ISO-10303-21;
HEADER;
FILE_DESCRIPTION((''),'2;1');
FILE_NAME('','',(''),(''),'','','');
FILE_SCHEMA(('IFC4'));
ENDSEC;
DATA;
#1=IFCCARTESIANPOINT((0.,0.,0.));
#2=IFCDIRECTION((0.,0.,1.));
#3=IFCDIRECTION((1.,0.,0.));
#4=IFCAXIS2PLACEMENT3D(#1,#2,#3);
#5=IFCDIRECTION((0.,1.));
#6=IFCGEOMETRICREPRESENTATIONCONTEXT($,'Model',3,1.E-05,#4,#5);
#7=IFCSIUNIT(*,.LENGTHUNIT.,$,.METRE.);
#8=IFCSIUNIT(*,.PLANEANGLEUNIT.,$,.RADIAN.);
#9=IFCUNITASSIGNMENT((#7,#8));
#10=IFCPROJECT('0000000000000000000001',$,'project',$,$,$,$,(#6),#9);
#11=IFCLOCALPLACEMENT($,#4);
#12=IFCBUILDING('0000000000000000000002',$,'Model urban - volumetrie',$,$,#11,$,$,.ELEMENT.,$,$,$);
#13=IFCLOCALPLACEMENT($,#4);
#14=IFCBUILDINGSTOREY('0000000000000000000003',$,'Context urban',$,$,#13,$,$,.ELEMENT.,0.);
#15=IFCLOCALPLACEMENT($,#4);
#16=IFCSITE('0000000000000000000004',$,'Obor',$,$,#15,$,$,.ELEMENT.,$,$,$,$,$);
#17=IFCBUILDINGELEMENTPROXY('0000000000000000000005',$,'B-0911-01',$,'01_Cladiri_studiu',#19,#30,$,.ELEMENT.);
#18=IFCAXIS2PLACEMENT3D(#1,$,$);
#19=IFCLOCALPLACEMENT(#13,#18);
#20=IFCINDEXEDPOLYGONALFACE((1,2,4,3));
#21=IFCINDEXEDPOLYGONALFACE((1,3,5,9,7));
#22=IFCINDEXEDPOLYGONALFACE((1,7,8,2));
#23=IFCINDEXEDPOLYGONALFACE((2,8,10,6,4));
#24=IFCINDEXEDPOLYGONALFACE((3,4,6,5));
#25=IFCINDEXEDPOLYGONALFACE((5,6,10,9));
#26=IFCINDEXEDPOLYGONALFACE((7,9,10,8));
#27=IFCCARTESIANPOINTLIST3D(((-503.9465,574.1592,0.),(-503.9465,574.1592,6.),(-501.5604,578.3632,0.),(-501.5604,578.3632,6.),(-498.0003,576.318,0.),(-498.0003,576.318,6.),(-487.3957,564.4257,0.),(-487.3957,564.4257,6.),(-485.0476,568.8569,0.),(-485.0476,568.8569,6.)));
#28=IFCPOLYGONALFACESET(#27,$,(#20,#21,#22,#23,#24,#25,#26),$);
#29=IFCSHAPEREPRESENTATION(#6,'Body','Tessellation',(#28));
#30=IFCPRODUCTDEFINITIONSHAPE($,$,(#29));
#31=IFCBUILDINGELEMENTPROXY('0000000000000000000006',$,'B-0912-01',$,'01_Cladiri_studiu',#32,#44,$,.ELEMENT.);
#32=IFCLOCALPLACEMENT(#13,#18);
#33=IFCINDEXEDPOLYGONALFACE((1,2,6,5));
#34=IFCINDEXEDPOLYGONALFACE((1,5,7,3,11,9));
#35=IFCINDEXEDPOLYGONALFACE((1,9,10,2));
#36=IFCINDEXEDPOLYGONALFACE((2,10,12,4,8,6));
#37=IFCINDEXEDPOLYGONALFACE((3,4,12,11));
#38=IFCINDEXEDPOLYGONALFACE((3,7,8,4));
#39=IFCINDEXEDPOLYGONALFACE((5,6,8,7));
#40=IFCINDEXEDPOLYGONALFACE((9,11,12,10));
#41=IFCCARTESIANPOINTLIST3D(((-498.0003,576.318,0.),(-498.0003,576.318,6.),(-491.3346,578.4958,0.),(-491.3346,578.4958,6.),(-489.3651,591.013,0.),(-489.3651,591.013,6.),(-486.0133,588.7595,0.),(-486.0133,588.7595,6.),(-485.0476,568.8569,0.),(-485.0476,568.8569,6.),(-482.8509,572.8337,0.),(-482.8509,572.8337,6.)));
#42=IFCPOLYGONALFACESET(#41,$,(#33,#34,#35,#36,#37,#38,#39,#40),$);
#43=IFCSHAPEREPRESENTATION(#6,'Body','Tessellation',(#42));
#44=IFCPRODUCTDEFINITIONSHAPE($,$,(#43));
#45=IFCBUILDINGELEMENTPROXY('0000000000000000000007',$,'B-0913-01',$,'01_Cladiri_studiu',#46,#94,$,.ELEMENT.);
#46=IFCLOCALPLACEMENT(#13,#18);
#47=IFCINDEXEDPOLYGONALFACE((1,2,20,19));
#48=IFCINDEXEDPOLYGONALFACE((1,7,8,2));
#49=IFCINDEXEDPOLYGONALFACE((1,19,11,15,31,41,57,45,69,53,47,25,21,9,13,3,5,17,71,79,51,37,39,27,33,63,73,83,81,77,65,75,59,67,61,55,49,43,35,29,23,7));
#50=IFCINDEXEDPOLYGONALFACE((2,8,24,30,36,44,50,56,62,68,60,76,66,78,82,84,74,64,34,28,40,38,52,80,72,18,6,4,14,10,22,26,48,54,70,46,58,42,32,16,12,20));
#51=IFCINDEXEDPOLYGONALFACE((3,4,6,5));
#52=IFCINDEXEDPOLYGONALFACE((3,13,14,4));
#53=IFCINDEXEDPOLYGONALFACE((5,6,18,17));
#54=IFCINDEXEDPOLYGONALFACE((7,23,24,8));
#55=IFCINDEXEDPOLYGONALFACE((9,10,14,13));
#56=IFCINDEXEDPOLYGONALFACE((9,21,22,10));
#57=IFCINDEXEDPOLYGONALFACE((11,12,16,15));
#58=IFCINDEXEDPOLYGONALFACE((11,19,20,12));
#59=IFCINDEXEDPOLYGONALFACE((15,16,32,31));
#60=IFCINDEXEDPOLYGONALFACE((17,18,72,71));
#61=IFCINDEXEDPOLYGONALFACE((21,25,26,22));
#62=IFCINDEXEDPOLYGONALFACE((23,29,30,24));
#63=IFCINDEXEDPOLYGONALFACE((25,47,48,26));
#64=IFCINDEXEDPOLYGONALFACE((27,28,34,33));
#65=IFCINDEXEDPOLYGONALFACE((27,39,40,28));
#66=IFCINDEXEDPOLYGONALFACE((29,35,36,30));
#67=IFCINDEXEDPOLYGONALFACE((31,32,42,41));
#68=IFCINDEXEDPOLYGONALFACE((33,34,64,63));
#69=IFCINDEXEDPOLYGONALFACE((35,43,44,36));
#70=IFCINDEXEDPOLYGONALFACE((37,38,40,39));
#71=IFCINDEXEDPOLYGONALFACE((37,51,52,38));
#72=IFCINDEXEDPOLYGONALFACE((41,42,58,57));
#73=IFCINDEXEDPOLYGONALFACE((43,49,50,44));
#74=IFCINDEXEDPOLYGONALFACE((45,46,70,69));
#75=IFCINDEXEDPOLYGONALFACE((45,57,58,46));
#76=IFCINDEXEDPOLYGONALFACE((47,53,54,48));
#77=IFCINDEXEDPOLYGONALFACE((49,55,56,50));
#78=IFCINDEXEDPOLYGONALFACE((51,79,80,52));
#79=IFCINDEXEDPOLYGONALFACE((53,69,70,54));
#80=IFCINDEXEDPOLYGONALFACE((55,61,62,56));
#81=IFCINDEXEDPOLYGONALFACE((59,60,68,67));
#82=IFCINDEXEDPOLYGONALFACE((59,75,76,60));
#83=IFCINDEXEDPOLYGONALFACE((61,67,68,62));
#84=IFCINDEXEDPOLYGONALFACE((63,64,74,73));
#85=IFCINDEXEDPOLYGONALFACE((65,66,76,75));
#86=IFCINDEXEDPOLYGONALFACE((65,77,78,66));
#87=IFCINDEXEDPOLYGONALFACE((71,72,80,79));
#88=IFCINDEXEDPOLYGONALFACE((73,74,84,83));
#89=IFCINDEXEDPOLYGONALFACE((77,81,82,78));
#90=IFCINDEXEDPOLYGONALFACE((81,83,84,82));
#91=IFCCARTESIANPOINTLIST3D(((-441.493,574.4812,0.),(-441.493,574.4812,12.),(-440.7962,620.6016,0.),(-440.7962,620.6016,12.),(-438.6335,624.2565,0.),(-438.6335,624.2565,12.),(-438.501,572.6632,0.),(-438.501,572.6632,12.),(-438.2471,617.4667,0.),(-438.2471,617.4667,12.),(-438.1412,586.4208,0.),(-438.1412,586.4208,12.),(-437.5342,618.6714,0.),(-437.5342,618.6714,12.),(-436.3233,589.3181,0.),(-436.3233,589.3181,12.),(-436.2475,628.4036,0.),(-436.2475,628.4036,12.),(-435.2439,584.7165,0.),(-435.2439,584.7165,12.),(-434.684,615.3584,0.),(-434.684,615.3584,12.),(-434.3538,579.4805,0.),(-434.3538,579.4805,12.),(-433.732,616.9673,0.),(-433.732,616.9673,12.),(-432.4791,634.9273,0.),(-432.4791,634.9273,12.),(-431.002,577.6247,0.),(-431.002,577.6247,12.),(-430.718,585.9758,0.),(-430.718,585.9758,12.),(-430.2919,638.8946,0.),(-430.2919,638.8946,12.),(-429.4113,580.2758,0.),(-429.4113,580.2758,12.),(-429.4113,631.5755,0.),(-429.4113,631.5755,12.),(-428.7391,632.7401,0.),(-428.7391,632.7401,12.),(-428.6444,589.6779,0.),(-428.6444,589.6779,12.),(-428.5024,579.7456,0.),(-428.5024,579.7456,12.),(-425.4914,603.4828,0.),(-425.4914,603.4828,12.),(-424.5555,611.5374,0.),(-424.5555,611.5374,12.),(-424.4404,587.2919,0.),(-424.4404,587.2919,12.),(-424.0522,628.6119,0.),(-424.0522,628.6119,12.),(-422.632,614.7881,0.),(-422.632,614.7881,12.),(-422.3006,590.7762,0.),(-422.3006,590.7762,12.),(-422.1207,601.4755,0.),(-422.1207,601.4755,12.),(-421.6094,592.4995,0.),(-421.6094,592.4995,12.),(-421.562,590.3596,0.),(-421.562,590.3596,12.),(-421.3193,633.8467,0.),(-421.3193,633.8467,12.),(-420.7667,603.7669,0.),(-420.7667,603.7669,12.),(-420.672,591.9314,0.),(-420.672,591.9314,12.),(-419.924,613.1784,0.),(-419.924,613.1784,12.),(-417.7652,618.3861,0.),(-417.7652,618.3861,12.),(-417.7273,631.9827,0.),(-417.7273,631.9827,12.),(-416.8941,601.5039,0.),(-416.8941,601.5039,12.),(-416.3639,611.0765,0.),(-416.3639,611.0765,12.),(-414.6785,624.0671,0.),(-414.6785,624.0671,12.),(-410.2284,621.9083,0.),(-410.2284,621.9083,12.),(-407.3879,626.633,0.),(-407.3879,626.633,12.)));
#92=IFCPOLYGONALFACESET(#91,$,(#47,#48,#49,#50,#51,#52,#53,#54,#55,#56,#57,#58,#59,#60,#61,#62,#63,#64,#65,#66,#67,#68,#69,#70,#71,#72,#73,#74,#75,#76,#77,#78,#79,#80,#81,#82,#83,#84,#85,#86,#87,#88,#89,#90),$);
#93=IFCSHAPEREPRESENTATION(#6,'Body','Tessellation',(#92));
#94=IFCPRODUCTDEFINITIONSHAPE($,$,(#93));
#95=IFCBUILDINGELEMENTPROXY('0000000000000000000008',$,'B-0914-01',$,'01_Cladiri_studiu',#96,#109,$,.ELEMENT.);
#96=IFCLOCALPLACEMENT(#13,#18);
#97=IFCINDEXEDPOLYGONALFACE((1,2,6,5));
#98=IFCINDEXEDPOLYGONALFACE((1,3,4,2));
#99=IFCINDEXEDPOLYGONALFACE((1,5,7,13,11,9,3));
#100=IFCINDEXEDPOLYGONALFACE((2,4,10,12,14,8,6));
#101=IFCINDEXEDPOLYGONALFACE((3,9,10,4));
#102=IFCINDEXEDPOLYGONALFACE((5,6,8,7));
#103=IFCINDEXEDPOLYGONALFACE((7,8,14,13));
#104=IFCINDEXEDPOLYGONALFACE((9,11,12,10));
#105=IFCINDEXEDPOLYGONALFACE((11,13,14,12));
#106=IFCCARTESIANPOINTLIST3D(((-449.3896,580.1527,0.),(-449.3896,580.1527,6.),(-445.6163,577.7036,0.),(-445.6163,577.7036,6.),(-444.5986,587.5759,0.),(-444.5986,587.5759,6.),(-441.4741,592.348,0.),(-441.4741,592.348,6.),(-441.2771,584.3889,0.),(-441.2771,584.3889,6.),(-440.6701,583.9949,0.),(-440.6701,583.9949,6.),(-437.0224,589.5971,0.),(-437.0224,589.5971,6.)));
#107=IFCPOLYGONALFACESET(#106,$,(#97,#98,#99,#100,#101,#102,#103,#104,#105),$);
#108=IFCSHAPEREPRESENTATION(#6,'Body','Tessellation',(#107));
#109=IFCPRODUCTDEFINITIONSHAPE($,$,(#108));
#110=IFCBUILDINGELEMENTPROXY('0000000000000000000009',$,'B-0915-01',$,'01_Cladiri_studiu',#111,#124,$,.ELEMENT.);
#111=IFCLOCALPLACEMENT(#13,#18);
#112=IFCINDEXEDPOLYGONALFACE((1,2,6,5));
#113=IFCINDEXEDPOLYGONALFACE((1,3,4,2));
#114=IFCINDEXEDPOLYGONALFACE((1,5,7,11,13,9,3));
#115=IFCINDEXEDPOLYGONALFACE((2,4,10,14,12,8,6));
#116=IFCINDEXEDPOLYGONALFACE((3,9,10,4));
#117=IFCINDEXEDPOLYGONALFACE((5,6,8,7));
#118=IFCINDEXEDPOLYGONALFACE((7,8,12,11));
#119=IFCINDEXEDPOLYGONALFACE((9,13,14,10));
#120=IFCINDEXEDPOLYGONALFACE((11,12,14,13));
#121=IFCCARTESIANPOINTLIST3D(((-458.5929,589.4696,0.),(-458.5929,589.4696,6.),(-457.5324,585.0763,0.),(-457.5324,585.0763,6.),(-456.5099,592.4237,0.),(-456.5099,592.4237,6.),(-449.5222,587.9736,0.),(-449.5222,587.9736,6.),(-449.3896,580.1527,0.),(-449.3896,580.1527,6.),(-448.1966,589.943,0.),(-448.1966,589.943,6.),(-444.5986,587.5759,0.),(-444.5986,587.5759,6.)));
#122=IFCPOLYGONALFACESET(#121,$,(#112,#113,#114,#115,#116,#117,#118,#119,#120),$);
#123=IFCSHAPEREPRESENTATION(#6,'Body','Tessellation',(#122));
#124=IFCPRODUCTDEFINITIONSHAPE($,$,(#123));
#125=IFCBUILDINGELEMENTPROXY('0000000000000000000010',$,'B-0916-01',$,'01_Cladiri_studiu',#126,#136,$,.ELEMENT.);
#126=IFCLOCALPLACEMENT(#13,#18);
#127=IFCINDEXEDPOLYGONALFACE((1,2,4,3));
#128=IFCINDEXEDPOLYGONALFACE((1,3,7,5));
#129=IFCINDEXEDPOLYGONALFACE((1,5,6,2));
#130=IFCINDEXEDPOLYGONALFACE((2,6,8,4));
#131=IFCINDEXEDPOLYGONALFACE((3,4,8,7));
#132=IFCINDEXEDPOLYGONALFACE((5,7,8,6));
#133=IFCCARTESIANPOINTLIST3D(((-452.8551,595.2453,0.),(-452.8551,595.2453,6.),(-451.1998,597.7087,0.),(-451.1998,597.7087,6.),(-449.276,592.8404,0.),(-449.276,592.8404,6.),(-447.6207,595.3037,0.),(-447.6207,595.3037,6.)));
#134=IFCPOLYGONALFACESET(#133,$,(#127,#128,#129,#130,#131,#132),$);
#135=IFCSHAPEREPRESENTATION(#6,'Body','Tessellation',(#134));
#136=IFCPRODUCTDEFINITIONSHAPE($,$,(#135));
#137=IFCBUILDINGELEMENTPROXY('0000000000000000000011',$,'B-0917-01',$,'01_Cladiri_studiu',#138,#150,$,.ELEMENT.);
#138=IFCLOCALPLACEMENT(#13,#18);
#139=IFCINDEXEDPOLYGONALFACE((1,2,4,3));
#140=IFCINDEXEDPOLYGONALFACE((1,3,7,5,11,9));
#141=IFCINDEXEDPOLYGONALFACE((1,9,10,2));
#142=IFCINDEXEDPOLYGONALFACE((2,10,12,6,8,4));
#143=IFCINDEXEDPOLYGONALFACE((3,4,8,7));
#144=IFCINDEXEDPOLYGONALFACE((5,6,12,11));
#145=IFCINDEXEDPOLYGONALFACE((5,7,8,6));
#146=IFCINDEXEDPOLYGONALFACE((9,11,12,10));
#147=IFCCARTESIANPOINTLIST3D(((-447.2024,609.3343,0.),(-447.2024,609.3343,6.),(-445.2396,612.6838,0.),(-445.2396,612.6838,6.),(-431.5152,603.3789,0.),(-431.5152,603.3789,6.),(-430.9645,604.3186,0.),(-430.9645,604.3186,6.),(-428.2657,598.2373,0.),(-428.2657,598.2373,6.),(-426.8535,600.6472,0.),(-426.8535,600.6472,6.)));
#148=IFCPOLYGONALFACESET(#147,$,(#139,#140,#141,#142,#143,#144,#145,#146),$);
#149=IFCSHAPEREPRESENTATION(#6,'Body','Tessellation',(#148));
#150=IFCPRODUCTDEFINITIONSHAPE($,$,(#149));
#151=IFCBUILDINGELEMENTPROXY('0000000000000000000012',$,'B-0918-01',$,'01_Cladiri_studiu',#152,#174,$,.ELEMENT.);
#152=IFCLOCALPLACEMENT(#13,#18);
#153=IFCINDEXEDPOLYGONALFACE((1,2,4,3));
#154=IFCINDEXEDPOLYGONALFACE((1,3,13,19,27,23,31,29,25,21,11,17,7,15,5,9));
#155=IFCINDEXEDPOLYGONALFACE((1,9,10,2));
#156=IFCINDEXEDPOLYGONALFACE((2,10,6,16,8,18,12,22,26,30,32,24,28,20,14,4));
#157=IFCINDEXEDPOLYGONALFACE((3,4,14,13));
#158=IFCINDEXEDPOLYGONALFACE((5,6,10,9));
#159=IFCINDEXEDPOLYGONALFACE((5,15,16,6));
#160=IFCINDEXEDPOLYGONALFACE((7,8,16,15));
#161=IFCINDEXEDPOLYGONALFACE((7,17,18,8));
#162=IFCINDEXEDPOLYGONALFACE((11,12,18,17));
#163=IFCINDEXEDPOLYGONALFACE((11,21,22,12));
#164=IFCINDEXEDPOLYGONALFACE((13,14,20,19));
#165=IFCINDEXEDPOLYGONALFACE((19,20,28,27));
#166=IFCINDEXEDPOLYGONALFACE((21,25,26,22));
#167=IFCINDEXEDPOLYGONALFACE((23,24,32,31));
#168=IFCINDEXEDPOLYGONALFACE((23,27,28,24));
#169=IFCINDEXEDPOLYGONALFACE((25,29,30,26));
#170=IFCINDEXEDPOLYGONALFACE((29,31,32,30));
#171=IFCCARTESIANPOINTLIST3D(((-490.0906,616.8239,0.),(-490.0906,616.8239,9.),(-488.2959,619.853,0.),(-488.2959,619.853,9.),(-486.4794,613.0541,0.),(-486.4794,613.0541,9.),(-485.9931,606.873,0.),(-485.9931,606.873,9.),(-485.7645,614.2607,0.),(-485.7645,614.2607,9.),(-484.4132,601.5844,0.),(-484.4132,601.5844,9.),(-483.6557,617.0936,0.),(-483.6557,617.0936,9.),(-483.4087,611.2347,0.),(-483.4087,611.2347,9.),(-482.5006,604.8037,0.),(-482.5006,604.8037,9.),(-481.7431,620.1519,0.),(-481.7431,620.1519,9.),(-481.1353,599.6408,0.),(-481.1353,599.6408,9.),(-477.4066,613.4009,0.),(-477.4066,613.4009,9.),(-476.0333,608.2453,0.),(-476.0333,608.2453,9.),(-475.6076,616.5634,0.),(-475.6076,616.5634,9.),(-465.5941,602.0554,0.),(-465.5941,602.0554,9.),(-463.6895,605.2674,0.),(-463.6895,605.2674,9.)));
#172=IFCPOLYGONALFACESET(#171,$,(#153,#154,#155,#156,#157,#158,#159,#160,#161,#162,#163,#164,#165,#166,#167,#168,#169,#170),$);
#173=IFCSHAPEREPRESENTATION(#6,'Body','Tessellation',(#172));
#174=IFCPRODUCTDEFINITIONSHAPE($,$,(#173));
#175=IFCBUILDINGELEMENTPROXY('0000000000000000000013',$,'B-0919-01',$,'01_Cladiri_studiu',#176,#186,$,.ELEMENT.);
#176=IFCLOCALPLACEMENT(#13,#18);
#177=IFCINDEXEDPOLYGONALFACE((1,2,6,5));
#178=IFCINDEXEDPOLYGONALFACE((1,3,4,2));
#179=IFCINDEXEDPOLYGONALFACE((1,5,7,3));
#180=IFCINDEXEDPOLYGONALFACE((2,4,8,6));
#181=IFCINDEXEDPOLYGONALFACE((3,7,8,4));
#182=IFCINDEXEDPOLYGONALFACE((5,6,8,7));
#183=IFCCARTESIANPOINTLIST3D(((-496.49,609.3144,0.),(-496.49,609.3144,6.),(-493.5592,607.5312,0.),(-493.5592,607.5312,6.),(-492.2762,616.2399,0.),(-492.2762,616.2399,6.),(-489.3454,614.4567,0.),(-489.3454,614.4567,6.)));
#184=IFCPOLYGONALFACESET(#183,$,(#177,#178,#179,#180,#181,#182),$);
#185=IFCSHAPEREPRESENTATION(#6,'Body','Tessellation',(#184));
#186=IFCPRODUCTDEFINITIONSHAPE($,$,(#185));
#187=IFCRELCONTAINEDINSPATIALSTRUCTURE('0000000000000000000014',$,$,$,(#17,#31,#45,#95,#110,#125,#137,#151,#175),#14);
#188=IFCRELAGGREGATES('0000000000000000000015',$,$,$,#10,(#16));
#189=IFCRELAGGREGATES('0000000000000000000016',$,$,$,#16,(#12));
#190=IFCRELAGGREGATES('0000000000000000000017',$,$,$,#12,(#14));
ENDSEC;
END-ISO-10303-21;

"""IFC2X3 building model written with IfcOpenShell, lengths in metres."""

from ifc_helpers import new_model, si_unit, direction, origin_with_axes, place, context, project, spatial, polyline, outline, extrude, element, save


model = new_model("IFC2X3")

# Units and contexts
model_context = context("Model", 3, precision=1e-05, world=origin_with_axes(), true_north=direction((0.0, 1.0)))
ifc_project = project(units=[si_unit("LENGTHUNIT", "METRE"), si_unit("PLANEANGLEUNIT", "RADIAN")], contexts=[model_context])

# Site, building, storey
site_placement = place(None, origin_with_axes())
site = spatial("IfcSite", under=ifc_project, at=site_placement, Name="Obor", CompositionType="ELEMENT")
building_placement = place(None, origin_with_axes())
building = spatial("IfcBuilding", under=site, at=building_placement, Name="Model urban - volumetrie", CompositionType="ELEMENT")
storey_placement = place(None, origin_with_axes())
storey = spatial("IfcBuildingStorey", under=building, at=storey_placement, Name="Context urban", CompositionType="ELEMENT", Elevation=0.0)

# Building element proxies
proxy_1_placement = place(None, origin_with_axes())
element("IfcBuildingElementProxy", 1, at=proxy_1_placement, inside=storey, Name="B-0911-01", ObjectType="01_Cladiri_studiu", CompositionType="ELEMENT", context=model_context, shape_type="SweptSolid", body=[
    extrude(outline(polyline([(-503.9465, 574.1592), (-487.3957, 564.4257), (-485.0476, 568.8569), (-498.0003, 576.318), (-501.5604, 578.3632), (-503.9465, 574.1592)])), origin_with_axes(), (0.0, 0.0, 1.0), 6.0),
])
proxy_2_placement = place(None, origin_with_axes())
element("IfcBuildingElementProxy", 2, at=proxy_2_placement, inside=storey, Name="B-0912-01", ObjectType="01_Cladiri_studiu", CompositionType="ELEMENT", context=model_context, shape_type="SweptSolid", body=[
    extrude(outline(polyline([(-486.0133, 588.7595), (-489.3651, 591.013), (-498.0003, 576.318), (-485.0476, 568.8569), (-482.8509, 572.8337), (-491.3346, 578.4958), (-486.0133, 588.7595)])), origin_with_axes(), (0.0, 0.0, 1.0), 6.0),
])
proxy_3_placement = place(None, origin_with_axes())
element("IfcBuildingElementProxy", 3, at=proxy_3_placement, inside=storey, Name="B-0913-01", ObjectType="01_Cladiri_studiu", CompositionType="ELEMENT", context=model_context, shape_type="SweptSolid", body=[
    extrude(outline(polyline([(-433.732, 616.9673), (-424.5555, 611.5374), (-422.632, 614.7881), (-419.924, 613.1784), (-425.4914, 603.4828), (-422.1207, 601.4755), (-428.6444, 589.6779), (-430.718, 585.9758), (-436.3233, 589.3181), (-438.1412, 586.4208), (-435.2439, 584.7165), (-441.493, 574.4812), (-438.501, 572.6632), (-434.3538, 579.4805), (-431.002, 577.6247), (-429.4113, 580.2758), (-428.5024, 579.7456), (-424.4404, 587.2919), (-422.3006, 590.7762), (-421.562, 590.3596), (-420.672, 591.9314), (-421.6094, 592.4995), (-416.8941, 601.5039), (-420.7667, 603.7669), (-416.3639, 611.0765), (-410.2284, 621.9083), (-407.3879, 626.633), (-417.7273, 631.9827), (-421.3193, 633.8467), (-430.2919, 638.8946), (-432.4791, 634.9273), (-428.7391, 632.7401), (-429.4113, 631.5755), (-424.0522, 628.6119), (-414.6785, 624.0671), (-417.7652, 618.3861), (-436.2475, 628.4036), (-438.6335, 624.2565), (-440.7962, 620.6016), (-437.5342, 618.6714), (-438.2471, 617.4667), (-434.684, 615.3584), (-433.732, 616.9673)])), origin_with_axes(), (0.0, 0.0, 1.0), 12.0),
])
proxy_4_placement = place(None, origin_with_axes())
element("IfcBuildingElementProxy", 4, at=proxy_4_placement, inside=storey, Name="B-0914-01", ObjectType="01_Cladiri_studiu", CompositionType="ELEMENT", context=model_context, shape_type="SweptSolid", body=[
    extrude(outline(polyline([(-449.3896, 580.1527), (-445.6163, 577.7036), (-441.2771, 584.3889), (-440.6701, 583.9949), (-437.0224, 589.5971), (-441.4741, 592.348), (-444.5986, 587.5759), (-449.3896, 580.1527)])), origin_with_axes(), (0.0, 0.0, 1.0), 6.0),
])
proxy_5_placement = place(None, origin_with_axes())
element("IfcBuildingElementProxy", 5, at=proxy_5_placement, inside=storey, Name="B-0915-01", ObjectType="01_Cladiri_studiu", CompositionType="ELEMENT", context=model_context, shape_type="SweptSolid", body=[
    extrude(outline(polyline([(-444.5986, 587.5759), (-448.1966, 589.943), (-449.5222, 587.9736), (-456.5099, 592.4237), (-458.5929, 589.4696), (-457.5324, 585.0763), (-449.3896, 580.1527), (-444.5986, 587.5759)])), origin_with_axes(), (0.0, 0.0, 1.0), 6.0),
])
proxy_6_placement = place(None, origin_with_axes())
element("IfcBuildingElementProxy", 6, at=proxy_6_placement, inside=storey, Name="B-0916-01", ObjectType="01_Cladiri_studiu", CompositionType="ELEMENT", context=model_context, shape_type="SweptSolid", body=[
    extrude(outline(polyline([(-447.6207, 595.3037), (-451.1998, 597.7087), (-452.8551, 595.2453), (-449.276, 592.8404), (-447.6207, 595.3037)])), origin_with_axes(), (0.0, 0.0, 1.0), 6.0),
])
proxy_7_placement = place(None, origin_with_axes())
element("IfcBuildingElementProxy", 7, at=proxy_7_placement, inside=storey, Name="B-0917-01", ObjectType="01_Cladiri_studiu", CompositionType="ELEMENT", context=model_context, shape_type="SweptSolid", body=[
    extrude(outline(polyline([(-431.5152, 603.3789), (-430.9645, 604.3186), (-445.2396, 612.6838), (-447.2024, 609.3343), (-428.2657, 598.2373), (-426.8535, 600.6472), (-431.5152, 603.3789)])), origin_with_axes(), (0.0, 0.0, 1.0), 6.0),
])
proxy_8_placement = place(None, origin_with_axes())
element("IfcBuildingElementProxy", 8, at=proxy_8_placement, inside=storey, Name="B-0918-01", ObjectType="01_Cladiri_studiu", CompositionType="ELEMENT", context=model_context, shape_type="SweptSolid", body=[
    extrude(outline(polyline([(-483.6557, 617.0936), (-488.2959, 619.853), (-490.0906, 616.8239), (-485.7645, 614.2607), (-486.4794, 613.0541), (-483.4087, 611.2347), (-485.9931, 606.873), (-482.5006, 604.8037), (-484.4132, 601.5844), (-481.1353, 599.6408), (-476.0333, 608.2453), (-465.5941, 602.0554), (-463.6895, 605.2674), (-477.4066, 613.4009), (-475.6076, 616.5634), (-481.7431, 620.1519), (-483.6557, 617.0936)])), origin_with_axes(), (0.0, 0.0, 1.0), 9.0),
])
proxy_9_placement = place(None, origin_with_axes())
element("IfcBuildingElementProxy", 9, at=proxy_9_placement, inside=storey, Name="B-0919-01", ObjectType="01_Cladiri_studiu", CompositionType="ELEMENT", context=model_context, shape_type="SweptSolid", body=[
    extrude(outline(polyline([(-489.3454, 614.4567), (-492.2762, 616.2399), (-496.49, 609.3144), (-493.5592, 607.5312), (-489.3454, 614.4567)])), origin_with_axes(), (0.0, 0.0, 1.0), 6.0),
])

save(model, "model.ifc")
